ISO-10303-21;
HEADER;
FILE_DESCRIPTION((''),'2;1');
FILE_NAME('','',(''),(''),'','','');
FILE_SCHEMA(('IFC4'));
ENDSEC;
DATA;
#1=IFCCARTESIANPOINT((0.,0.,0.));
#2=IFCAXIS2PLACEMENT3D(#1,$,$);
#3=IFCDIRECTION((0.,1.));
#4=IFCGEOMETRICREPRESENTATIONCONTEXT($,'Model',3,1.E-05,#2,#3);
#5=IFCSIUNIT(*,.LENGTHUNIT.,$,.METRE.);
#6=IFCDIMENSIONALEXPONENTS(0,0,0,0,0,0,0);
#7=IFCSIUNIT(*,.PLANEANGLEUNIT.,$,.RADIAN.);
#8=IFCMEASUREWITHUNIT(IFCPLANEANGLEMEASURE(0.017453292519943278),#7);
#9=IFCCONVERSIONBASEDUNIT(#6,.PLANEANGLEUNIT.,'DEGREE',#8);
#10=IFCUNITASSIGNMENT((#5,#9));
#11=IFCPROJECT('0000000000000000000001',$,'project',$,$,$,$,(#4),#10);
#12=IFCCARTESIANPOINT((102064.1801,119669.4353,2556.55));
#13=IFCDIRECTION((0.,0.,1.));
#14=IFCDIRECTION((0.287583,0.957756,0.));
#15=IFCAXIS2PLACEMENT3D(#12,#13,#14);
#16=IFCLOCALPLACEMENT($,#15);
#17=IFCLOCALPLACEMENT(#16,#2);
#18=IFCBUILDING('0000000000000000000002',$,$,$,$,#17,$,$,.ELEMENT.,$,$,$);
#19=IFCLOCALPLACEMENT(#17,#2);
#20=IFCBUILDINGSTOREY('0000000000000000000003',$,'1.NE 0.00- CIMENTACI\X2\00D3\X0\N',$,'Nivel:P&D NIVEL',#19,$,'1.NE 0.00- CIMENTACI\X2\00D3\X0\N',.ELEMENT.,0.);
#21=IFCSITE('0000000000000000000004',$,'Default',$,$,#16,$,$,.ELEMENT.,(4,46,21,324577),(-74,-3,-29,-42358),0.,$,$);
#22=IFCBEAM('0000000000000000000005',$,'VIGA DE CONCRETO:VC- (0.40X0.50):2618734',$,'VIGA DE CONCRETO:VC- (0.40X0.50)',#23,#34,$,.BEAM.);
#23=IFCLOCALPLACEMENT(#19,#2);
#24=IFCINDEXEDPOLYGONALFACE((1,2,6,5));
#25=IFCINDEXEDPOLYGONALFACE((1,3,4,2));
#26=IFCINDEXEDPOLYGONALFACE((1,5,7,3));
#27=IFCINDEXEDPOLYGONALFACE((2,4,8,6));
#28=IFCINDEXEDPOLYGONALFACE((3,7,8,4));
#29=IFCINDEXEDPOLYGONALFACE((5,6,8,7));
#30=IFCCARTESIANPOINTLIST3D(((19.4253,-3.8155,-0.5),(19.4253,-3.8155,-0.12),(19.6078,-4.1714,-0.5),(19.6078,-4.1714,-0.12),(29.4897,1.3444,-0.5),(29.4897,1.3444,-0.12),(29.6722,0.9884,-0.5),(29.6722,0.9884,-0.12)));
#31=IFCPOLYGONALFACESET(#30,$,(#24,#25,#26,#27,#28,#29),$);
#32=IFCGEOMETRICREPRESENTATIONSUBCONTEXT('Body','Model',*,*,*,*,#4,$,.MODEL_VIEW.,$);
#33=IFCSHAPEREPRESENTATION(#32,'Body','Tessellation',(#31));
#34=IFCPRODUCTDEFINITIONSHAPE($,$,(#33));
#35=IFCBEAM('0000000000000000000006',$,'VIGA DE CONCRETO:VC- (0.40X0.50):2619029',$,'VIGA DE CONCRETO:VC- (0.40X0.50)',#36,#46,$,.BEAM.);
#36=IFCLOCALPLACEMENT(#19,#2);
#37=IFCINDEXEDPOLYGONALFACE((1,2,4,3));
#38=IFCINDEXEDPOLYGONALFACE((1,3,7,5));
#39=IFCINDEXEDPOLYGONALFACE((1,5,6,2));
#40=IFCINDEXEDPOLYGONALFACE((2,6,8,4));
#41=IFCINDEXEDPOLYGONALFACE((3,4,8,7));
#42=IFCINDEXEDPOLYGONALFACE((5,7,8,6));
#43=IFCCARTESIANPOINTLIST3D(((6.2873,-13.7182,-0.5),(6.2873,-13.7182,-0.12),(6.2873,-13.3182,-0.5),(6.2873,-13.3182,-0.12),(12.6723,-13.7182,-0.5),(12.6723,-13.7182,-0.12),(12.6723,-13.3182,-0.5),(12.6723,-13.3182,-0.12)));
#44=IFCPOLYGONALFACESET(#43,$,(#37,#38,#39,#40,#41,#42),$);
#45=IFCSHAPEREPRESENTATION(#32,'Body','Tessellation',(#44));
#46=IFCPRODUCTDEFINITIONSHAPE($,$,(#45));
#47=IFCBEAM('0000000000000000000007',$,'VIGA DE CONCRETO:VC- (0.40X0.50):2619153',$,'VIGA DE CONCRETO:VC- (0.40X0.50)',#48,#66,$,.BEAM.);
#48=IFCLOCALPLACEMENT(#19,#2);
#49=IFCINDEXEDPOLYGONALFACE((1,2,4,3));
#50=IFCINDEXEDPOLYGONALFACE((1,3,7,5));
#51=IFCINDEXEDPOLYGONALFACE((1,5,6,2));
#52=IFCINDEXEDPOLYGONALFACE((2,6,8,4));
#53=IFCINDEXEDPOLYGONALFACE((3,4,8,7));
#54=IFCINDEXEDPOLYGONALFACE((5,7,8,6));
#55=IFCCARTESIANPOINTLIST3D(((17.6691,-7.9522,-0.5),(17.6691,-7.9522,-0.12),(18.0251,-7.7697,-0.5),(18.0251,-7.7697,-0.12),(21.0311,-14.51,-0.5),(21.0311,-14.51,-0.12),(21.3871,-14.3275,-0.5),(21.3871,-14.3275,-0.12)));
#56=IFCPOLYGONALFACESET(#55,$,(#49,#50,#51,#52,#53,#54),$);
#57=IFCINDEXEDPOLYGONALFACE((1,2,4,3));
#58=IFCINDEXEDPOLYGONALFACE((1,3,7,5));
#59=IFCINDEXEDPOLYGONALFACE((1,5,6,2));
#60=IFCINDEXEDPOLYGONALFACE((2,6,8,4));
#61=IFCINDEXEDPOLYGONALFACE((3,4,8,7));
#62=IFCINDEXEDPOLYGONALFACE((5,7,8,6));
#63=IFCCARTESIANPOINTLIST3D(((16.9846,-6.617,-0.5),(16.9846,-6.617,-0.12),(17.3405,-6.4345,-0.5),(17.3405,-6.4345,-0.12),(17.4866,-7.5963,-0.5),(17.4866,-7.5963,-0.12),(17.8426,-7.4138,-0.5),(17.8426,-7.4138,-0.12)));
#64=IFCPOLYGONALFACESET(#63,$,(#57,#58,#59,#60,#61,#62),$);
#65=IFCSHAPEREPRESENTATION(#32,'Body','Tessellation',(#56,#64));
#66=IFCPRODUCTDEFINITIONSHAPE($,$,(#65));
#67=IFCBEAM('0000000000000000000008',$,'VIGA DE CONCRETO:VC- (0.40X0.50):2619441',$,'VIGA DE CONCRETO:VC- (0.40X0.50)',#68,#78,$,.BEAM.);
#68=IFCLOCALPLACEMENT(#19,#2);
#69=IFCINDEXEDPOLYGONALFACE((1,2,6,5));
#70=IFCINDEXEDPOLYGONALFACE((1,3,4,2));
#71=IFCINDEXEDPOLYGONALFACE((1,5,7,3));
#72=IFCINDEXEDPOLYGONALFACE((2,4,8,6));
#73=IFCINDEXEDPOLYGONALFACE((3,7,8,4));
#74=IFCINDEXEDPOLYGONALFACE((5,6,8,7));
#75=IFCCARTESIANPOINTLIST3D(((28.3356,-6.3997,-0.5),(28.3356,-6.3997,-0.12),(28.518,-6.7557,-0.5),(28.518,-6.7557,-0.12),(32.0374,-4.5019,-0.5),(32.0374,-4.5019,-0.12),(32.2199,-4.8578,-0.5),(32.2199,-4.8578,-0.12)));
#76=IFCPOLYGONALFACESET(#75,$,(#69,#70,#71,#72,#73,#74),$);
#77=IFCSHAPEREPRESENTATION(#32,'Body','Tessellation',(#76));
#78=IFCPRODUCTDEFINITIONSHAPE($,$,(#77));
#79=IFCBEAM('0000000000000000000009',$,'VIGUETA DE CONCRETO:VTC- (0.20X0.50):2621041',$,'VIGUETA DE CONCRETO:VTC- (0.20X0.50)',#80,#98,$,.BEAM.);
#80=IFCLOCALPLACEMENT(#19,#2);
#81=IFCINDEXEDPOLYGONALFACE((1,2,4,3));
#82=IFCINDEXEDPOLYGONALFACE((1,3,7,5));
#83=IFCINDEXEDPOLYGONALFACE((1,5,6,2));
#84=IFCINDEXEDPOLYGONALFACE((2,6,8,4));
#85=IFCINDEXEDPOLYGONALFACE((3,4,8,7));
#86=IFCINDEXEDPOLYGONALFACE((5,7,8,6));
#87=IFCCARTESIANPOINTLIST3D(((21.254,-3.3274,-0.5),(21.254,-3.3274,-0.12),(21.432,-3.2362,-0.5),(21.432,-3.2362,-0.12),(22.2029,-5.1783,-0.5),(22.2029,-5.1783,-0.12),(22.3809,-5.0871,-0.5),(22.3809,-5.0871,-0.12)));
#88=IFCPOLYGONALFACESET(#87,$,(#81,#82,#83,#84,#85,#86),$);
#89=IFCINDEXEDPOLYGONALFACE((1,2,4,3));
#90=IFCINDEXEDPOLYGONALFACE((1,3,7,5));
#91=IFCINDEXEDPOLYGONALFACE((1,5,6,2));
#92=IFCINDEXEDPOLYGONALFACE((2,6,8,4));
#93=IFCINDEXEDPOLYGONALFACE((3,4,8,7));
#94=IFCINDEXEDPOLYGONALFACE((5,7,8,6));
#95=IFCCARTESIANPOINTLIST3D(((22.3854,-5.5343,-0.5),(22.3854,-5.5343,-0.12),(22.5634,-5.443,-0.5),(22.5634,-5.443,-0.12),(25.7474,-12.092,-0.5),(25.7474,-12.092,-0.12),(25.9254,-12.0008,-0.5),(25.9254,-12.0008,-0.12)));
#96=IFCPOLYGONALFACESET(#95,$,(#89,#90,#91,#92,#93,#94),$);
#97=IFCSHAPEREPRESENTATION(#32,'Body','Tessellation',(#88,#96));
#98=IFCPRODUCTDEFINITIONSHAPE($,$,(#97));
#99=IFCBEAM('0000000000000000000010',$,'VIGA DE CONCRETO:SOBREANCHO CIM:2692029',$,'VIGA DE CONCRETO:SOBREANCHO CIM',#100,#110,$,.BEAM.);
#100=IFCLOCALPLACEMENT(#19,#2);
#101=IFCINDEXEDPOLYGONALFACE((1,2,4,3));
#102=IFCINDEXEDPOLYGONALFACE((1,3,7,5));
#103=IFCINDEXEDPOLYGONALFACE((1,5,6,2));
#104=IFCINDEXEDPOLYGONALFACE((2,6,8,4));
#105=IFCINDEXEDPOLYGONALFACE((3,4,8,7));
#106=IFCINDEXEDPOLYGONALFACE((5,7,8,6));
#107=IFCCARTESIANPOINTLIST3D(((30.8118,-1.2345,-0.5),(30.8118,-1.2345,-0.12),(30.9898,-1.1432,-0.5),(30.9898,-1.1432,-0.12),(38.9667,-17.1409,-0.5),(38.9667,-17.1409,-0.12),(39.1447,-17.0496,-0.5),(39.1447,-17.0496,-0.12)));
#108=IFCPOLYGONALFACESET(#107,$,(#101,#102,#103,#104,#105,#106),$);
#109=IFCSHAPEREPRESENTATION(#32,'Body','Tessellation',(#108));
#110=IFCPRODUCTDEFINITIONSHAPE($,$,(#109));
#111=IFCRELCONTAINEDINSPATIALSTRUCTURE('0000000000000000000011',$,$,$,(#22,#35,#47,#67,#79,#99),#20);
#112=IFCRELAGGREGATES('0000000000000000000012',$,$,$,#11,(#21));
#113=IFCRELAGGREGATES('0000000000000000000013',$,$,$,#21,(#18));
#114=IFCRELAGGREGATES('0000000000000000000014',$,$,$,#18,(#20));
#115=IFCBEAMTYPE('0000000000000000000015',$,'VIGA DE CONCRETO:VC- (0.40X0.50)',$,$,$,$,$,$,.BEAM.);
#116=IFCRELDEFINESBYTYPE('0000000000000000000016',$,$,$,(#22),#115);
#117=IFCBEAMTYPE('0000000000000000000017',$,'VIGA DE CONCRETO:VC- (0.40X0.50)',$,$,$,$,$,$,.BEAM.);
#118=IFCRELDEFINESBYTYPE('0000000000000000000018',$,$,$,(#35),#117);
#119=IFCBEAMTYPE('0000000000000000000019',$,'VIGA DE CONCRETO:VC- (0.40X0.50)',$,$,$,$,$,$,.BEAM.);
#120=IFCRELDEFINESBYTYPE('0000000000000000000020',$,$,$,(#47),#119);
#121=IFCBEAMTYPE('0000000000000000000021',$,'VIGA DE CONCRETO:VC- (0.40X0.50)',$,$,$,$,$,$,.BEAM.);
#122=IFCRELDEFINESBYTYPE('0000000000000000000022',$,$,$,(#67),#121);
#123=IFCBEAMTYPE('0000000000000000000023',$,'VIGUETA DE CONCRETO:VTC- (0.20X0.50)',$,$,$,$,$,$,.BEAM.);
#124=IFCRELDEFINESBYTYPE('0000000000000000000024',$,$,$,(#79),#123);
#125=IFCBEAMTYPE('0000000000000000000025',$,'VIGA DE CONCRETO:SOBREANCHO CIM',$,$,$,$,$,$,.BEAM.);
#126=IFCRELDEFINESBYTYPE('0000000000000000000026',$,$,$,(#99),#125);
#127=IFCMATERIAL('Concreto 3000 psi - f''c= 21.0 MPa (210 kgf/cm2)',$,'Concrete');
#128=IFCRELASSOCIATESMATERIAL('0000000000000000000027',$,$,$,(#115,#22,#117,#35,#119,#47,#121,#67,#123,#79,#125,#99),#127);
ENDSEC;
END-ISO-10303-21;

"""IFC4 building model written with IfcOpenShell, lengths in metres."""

from ifc_helpers import new_model, entity, si_unit, converted_unit, direction, frame, origin, place, context, subcontext, project, spatial, indexed_curve, outline, extrude, source, transform, mapped, material, type_object, type_shapes, element, save


model = new_model("IFC4")

# Units and contexts
model_context = context("Model", 3, precision=1e-05, world=origin(), true_north=direction((0.0, 1.0)))
body_context = subcontext(model_context, "Body", "Model", "MODEL_VIEW")
ifc_project = project(units=[si_unit("LENGTHUNIT", "METRE"), converted_unit("PLANEANGLEUNIT", "DEGREE", entity("IfcPlaneAngleMeasure", 0.017453292519943278), si_unit("PLANEANGLEUNIT", "RADIAN"), dimensions=[0, 0, 0, 0, 0, 0, 0])], contexts=[model_context])

# Site, building, storey
site_placement = place(None, frame((102064.1801, 119669.4353, 2556.55), z_axis=(0.0, 0.0, 1.0), x_axis=(0.287583, 0.957756, 0.0)))
site = spatial("IfcSite", under=ifc_project, at=site_placement, Name="Default", CompositionType="ELEMENT", RefLatitude=(4, 46, 21, 324577), RefLongitude=(-74, -3, -29, -42358), RefElevation=0.0)
building_placement = place(site_placement, origin())
building = spatial("IfcBuilding", under=site, at=building_placement, CompositionType="ELEMENT")
storey_placement = place(building_placement, origin())
storey = spatial("IfcBuildingStorey", under=building, at=storey_placement, Name="1.NE 0.00- CIMENTACIÓN", ObjectType="Nivel:P&D NIVEL", LongName="1.NE 0.00- CIMENTACIÓN", CompositionType="ELEMENT", Elevation=0.0)

# Shared definitions
ifc_material = material(Name="Concreto 3000 psi - f'c= 21.0 MPa (210 kgf/cm2)", Category="Concrete")

# Beams
beam_type_1 = type_object("IfcBeamType", Name="VIGA DE CONCRETO:VC- (0.40X0.50)", PredefinedType="BEAM", material=ifc_material)
shared_shape_1 = source(origin(), body_context, "Body", "SweptSolid", [
    extrude(outline(indexed_curve([(-0.19, -0.2), (0.19, -0.2), (0.19, 0.2), (-0.19, 0.2), (-0.19, -0.2)], self_intersect=False)), frame((19.5165, -3.9934, -0.31), z_axis=(0.889869, 0.456217, 0.0), x_axis=(0.0, 0.0, 1.0)), (0.0, 0.0, 1.0), 11.31),
])
type_shapes(beam_type_1, [shared_shape_1])
beam_1_placement = place(storey_placement, origin())
element("IfcBeam", 1, at=beam_1_placement, inside=storey, type_object=beam_type_1, material=ifc_material, Name="VIGA DE CONCRETO:VC- (0.40X0.50):2618734", ObjectType="VIGA DE CONCRETO:VC- (0.40X0.50)", PredefinedType="BEAM", context=body_context, shape_type="MappedRepresentation", body=[
    mapped(shared_shape_1, transform((0.0, 0.0, 0.0), scale=1.0)),
])
beam_type_2 = type_object("IfcBeamType", Name="VIGA DE CONCRETO:VC- (0.40X0.50)", PredefinedType="BEAM", material=ifc_material)
shared_shape_2 = source(origin(), body_context, "Body", "SweptSolid", [
    extrude(outline(indexed_curve([(-0.19, -0.2), (0.19, -0.2), (0.19, 0.2), (-0.19, 0.2), (-0.19, -0.2)], self_intersect=False)), frame((6.2873, -13.5182, -0.31), z_axis=(1.0, 0.0, 0.0), x_axis=(0.0, 0.0, -1.0)), (0.0, 0.0, 1.0), 6.385),
])
type_shapes(beam_type_2, [shared_shape_2])
beam_2_placement = place(storey_placement, origin())
element("IfcBeam", 2, at=beam_2_placement, inside=storey, type_object=beam_type_2, material=ifc_material, Name="VIGA DE CONCRETO:VC- (0.40X0.50):2619029", ObjectType="VIGA DE CONCRETO:VC- (0.40X0.50)", PredefinedType="BEAM", context=body_context, shape_type="MappedRepresentation", body=[
    mapped(shared_shape_2, transform((0.0, 0.0, 0.0), scale=1.0)),
])
beam_type_3 = type_object("IfcBeamType", Name="VIGA DE CONCRETO:VC- (0.40X0.50)", PredefinedType="BEAM", material=ifc_material)
shared_shape_3 = source(origin(), body_context, "Body", "SweptSolid", [
    extrude(outline(indexed_curve([(-0.19, -0.2), (0.19, -0.2), (0.19, 0.2), (-0.19, 0.2), (-0.19, -0.2)], self_intersect=False)), frame((21.2091, -14.4187, -0.31), z_axis=(-0.456217, 0.889869, 0.0), x_axis=(0.0, 0.0, 1.0)), (0.0, 0.0, 1.0), 7.3693),
    extrude(outline(indexed_curve([(-0.19, -0.2), (0.19, -0.2), (0.19, 0.2), (-0.19, 0.2), (-0.19, -0.2)], self_intersect=False)), frame((17.6646, -7.505, -0.31), z_axis=(-0.456217, 0.889869, 0.0), x_axis=(0.0, 0.0, 1.0)), (0.0, 0.0, 1.0), 1.1005),
])
type_shapes(beam_type_3, [shared_shape_3])
beam_3_placement = place(storey_placement, origin())
element("IfcBeam", 3, at=beam_3_placement, inside=storey, type_object=beam_type_3, material=ifc_material, Name="VIGA DE CONCRETO:VC- (0.40X0.50):2619153", ObjectType="VIGA DE CONCRETO:VC- (0.40X0.50)", PredefinedType="BEAM", context=body_context, shape_type="MappedRepresentation", body=[
    mapped(shared_shape_3, transform((0.0, 0.0, 0.0), scale=1.0)),
])
beam_type_4 = type_object("IfcBeamType", Name="VIGA DE CONCRETO:VC- (0.40X0.50)", PredefinedType="BEAM", material=ifc_material)
shared_shape_4 = source(origin(), body_context, "Body", "SweptSolid", [
    extrude(outline(indexed_curve([(-0.19, -0.2), (0.19, -0.2), (0.19, 0.2), (-0.19, 0.2), (-0.19, -0.2)], self_intersect=False)), frame((28.4268, -6.5777, -0.31), z_axis=(0.889869, 0.456217, 0.0), x_axis=(0.0, 0.0, 1.0)), (0.0, 0.0, 1.0), 4.16),
])
type_shapes(beam_type_4, [shared_shape_4])
beam_4_placement = place(storey_placement, origin())
element("IfcBeam", 4, at=beam_4_placement, inside=storey, type_object=beam_type_4, material=ifc_material, Name="VIGA DE CONCRETO:VC- (0.40X0.50):2619441", ObjectType="VIGA DE CONCRETO:VC- (0.40X0.50)", PredefinedType="BEAM", context=body_context, shape_type="MappedRepresentation", body=[
    mapped(shared_shape_4, transform((0.0, 0.0, 0.0), scale=1.0)),
])
beam_type_5 = type_object("IfcBeamType", Name="VIGUETA DE CONCRETO:VTC- (0.20X0.50)", PredefinedType="BEAM", material=ifc_material)
shared_shape_5 = source(origin(), body_context, "Body", "SweptSolid", [
    extrude(outline(indexed_curve([(-0.19, -0.1), (0.19, -0.1), (0.19, 0.1), (-0.19, 0.1), (-0.19, -0.1)], self_intersect=False)), frame((22.2919, -5.1327, -0.31), z_axis=(-0.456217, 0.889869, 0.0), x_axis=(0.0, 0.0, 1.0)), (0.0, 0.0, 1.0), 2.08),
    extrude(outline(indexed_curve([(-0.19, -0.1), (0.19, -0.1), (0.19, 0.1), (-0.19, 0.1), (-0.19, -0.1)], self_intersect=False)), frame((25.8364, -12.0464, -0.31), z_axis=(-0.456217, 0.889869, 0.0), x_axis=(0.0, 0.0, 1.0)), (0.0, 0.0, 1.0), 7.3693),
])
type_shapes(beam_type_5, [shared_shape_5])
beam_5_placement = place(storey_placement, origin())
element("IfcBeam", 5, at=beam_5_placement, inside=storey, type_object=beam_type_5, material=ifc_material, Name="VIGUETA DE CONCRETO:VTC- (0.20X0.50):2621041", ObjectType="VIGUETA DE CONCRETO:VTC- (0.20X0.50)", PredefinedType="BEAM", context=body_context, shape_type="MappedRepresentation", body=[
    mapped(shared_shape_5, transform((0.0, 0.0, 0.0), scale=1.0)),
])
beam_type_6 = type_object("IfcBeamType", Name="VIGA DE CONCRETO:SOBREANCHO CIM", PredefinedType="BEAM", material=ifc_material)
shared_shape_6 = source(origin(), body_context, "Body", "SweptSolid", [
    extrude(outline(indexed_curve([(-0.19, -0.1), (0.19, -0.1), (0.19, 0.1), (-0.19, 0.1), (-0.19, -0.1)], self_intersect=False)), frame((30.9008, -1.1889, -0.31), z_axis=(0.456217, -0.889869, 0.0), x_axis=(0.0, 0.0, -1.0)), (0.0, 0.0, 1.0), 17.875),
])
type_shapes(beam_type_6, [shared_shape_6])
beam_6_placement = place(storey_placement, origin())
element("IfcBeam", 6, at=beam_6_placement, inside=storey, type_object=beam_type_6, material=ifc_material, Name="VIGA DE CONCRETO:SOBREANCHO CIM:2692029", ObjectType="VIGA DE CONCRETO:SOBREANCHO CIM", PredefinedType="BEAM", context=body_context, shape_type="MappedRepresentation", body=[
    mapped(shared_shape_6, transform((0.0, 0.0, 0.0), scale=1.0)),
])

save(model, "model.ifc")
